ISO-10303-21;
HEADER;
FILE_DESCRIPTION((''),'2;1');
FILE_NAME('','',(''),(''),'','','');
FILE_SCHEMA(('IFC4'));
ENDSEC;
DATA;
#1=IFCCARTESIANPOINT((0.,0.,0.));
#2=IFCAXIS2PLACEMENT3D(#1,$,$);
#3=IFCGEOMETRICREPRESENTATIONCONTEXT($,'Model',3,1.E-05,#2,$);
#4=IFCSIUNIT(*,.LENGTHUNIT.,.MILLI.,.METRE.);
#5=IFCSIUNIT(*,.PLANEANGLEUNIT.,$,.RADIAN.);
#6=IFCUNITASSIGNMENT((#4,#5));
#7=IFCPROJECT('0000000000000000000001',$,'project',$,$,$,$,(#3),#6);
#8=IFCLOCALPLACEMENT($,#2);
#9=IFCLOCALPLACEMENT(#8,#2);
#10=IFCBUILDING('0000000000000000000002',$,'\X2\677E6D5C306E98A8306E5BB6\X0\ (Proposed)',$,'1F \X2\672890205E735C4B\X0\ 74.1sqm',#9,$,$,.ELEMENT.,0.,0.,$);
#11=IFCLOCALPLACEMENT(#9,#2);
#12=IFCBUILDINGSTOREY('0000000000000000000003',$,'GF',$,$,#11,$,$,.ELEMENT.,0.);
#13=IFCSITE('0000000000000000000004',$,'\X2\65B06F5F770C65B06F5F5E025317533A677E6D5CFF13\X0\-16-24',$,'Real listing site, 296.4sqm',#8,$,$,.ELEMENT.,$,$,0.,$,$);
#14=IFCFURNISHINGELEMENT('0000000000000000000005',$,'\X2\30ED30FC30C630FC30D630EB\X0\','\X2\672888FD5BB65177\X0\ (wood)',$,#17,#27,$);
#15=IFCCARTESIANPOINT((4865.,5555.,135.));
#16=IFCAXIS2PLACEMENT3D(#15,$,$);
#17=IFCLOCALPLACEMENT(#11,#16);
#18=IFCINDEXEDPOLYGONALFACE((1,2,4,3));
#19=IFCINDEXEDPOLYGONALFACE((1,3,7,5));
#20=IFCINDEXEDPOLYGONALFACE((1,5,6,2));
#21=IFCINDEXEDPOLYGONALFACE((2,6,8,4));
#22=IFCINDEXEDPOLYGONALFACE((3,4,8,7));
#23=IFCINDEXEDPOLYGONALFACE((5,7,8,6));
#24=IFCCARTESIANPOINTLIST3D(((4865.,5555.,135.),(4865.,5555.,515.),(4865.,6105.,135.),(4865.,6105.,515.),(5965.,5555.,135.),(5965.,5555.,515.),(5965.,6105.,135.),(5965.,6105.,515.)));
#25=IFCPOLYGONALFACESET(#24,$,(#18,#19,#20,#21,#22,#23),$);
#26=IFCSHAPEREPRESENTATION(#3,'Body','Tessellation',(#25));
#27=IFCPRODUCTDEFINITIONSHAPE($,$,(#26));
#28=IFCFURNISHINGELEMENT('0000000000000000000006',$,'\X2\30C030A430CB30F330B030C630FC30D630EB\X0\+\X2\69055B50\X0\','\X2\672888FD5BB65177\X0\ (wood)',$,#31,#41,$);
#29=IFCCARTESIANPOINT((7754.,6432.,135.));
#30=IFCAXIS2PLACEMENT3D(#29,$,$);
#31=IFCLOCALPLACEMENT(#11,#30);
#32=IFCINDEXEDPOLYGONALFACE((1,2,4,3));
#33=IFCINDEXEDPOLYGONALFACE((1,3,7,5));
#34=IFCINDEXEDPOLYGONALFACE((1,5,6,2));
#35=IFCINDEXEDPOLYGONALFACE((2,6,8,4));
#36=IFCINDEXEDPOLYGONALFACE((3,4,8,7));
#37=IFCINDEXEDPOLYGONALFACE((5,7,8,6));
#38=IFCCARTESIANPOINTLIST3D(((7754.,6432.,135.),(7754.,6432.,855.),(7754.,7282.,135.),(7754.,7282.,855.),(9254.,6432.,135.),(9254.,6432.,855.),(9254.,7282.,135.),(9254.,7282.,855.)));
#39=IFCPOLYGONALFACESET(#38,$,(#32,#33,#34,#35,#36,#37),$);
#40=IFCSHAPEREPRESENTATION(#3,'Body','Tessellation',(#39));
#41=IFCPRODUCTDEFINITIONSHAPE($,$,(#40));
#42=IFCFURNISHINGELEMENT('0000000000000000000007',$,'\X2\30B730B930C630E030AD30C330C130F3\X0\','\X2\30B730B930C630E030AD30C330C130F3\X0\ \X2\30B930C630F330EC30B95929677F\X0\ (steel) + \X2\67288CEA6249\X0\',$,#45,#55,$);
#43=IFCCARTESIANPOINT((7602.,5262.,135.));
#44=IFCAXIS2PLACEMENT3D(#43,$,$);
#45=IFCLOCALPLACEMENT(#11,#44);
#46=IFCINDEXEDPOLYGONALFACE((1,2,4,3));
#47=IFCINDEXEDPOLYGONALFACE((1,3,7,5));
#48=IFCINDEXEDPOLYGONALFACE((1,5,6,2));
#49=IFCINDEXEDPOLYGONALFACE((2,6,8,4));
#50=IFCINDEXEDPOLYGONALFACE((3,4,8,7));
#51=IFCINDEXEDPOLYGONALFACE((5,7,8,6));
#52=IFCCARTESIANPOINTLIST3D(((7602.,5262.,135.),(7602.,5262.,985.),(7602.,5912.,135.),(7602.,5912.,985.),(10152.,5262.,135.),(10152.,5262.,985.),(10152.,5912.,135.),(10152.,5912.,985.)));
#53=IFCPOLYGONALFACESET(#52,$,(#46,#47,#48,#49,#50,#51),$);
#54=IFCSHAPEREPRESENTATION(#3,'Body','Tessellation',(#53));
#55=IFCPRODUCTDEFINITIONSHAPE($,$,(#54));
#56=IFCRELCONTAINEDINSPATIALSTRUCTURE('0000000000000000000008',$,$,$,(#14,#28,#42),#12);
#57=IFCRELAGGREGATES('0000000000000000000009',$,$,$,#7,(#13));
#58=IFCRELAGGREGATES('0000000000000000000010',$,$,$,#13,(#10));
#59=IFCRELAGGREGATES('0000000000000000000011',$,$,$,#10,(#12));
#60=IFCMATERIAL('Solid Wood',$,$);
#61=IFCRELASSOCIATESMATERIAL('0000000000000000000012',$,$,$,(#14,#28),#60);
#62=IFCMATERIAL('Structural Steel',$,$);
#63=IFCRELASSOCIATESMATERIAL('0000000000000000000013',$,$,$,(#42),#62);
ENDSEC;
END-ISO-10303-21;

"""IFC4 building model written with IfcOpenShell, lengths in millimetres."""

from ifc_helpers import new_model, si_unit, frame, frame_2d, origin, place, context, project, spatial, rectangle, extrude, material, element, save


model = new_model("IFC4")

# Units and contexts
model_context = context("Model", 3, precision=1e-05, world=origin())
ifc_project = project(units=[si_unit("LENGTHUNIT", "METRE", prefix="MILLI"), si_unit("PLANEANGLEUNIT", "RADIAN")], contexts=[model_context])

# Site, building, storey
site_placement = place(None, origin())
site = spatial("IfcSite", under=ifc_project, at=site_placement, Name="新潟県新潟市北区松浜３-16-24", ObjectType="Real listing site, 296.4sqm", CompositionType="ELEMENT", RefElevation=0.0)
building_placement = place(site_placement, origin())
building = spatial("IfcBuilding", under=site, at=building_placement, Name="松浜の風の家 (Proposed)", ObjectType="1F 木造平屋 74.1sqm", CompositionType="ELEMENT", ElevationOfRefHeight=0.0, ElevationOfTerrain=0.0)
storey_placement = place(building_placement, origin())
storey = spatial("IfcBuildingStorey", under=building, at=storey_placement, Name="GF", CompositionType="ELEMENT", Elevation=0.0)

# Shared definitions
ifc_material_1 = material(Name="Solid Wood")

# Shared definitions
ifc_material_2 = material(Name="Structural Steel")

# Furnishing elements
furnishing_1_placement = place(storey_placement, frame((4865.0, 5555.0, 135.0)))
element("IfcFurnishingElement", 1, at=furnishing_1_placement, inside=storey, material=ifc_material_1, Name="ローテーブル", Description="木製家具 (wood)", context=model_context, shape_type="SweptSolid", body=[
    extrude(rectangle(XDim=1100.0, YDim=550.0, at=frame_2d((550.0, 275.0))), frame((4865.0, 5555.0, 135.0)), (0.0, 0.0, 1.0), 380.0),
])
furnishing_2_placement = place(storey_placement, frame((7754.0, 6432.0, 135.0)))
element("IfcFurnishingElement", 2, at=furnishing_2_placement, inside=storey, material=ifc_material_1, Name="ダイニングテーブル+椅子", Description="木製家具 (wood)", context=model_context, shape_type="SweptSolid", body=[
    extrude(rectangle(XDim=1500.0, YDim=850.0, at=frame_2d((750.0, 425.0))), frame((7754.0, 6432.0, 135.0)), (0.0, 0.0, 1.0), 720.0),
])
furnishing_3_placement = place(storey_placement, frame((7602.0, 5262.0, 135.0)))
element("IfcFurnishingElement", 3, at=furnishing_3_placement, inside=storey, material=ifc_material_2, Name="システムキッチン", Description="システムキッチン ステンレス天板 (steel) + 木質扉", context=model_context, shape_type="SweptSolid", body=[
    extrude(rectangle(XDim=2550.0, YDim=650.0, at=frame_2d((1275.0, 325.0))), frame((7602.0, 5262.0, 135.0)), (0.0, 0.0, 1.0), 850.0),
])

save(model, "model.ifc")
